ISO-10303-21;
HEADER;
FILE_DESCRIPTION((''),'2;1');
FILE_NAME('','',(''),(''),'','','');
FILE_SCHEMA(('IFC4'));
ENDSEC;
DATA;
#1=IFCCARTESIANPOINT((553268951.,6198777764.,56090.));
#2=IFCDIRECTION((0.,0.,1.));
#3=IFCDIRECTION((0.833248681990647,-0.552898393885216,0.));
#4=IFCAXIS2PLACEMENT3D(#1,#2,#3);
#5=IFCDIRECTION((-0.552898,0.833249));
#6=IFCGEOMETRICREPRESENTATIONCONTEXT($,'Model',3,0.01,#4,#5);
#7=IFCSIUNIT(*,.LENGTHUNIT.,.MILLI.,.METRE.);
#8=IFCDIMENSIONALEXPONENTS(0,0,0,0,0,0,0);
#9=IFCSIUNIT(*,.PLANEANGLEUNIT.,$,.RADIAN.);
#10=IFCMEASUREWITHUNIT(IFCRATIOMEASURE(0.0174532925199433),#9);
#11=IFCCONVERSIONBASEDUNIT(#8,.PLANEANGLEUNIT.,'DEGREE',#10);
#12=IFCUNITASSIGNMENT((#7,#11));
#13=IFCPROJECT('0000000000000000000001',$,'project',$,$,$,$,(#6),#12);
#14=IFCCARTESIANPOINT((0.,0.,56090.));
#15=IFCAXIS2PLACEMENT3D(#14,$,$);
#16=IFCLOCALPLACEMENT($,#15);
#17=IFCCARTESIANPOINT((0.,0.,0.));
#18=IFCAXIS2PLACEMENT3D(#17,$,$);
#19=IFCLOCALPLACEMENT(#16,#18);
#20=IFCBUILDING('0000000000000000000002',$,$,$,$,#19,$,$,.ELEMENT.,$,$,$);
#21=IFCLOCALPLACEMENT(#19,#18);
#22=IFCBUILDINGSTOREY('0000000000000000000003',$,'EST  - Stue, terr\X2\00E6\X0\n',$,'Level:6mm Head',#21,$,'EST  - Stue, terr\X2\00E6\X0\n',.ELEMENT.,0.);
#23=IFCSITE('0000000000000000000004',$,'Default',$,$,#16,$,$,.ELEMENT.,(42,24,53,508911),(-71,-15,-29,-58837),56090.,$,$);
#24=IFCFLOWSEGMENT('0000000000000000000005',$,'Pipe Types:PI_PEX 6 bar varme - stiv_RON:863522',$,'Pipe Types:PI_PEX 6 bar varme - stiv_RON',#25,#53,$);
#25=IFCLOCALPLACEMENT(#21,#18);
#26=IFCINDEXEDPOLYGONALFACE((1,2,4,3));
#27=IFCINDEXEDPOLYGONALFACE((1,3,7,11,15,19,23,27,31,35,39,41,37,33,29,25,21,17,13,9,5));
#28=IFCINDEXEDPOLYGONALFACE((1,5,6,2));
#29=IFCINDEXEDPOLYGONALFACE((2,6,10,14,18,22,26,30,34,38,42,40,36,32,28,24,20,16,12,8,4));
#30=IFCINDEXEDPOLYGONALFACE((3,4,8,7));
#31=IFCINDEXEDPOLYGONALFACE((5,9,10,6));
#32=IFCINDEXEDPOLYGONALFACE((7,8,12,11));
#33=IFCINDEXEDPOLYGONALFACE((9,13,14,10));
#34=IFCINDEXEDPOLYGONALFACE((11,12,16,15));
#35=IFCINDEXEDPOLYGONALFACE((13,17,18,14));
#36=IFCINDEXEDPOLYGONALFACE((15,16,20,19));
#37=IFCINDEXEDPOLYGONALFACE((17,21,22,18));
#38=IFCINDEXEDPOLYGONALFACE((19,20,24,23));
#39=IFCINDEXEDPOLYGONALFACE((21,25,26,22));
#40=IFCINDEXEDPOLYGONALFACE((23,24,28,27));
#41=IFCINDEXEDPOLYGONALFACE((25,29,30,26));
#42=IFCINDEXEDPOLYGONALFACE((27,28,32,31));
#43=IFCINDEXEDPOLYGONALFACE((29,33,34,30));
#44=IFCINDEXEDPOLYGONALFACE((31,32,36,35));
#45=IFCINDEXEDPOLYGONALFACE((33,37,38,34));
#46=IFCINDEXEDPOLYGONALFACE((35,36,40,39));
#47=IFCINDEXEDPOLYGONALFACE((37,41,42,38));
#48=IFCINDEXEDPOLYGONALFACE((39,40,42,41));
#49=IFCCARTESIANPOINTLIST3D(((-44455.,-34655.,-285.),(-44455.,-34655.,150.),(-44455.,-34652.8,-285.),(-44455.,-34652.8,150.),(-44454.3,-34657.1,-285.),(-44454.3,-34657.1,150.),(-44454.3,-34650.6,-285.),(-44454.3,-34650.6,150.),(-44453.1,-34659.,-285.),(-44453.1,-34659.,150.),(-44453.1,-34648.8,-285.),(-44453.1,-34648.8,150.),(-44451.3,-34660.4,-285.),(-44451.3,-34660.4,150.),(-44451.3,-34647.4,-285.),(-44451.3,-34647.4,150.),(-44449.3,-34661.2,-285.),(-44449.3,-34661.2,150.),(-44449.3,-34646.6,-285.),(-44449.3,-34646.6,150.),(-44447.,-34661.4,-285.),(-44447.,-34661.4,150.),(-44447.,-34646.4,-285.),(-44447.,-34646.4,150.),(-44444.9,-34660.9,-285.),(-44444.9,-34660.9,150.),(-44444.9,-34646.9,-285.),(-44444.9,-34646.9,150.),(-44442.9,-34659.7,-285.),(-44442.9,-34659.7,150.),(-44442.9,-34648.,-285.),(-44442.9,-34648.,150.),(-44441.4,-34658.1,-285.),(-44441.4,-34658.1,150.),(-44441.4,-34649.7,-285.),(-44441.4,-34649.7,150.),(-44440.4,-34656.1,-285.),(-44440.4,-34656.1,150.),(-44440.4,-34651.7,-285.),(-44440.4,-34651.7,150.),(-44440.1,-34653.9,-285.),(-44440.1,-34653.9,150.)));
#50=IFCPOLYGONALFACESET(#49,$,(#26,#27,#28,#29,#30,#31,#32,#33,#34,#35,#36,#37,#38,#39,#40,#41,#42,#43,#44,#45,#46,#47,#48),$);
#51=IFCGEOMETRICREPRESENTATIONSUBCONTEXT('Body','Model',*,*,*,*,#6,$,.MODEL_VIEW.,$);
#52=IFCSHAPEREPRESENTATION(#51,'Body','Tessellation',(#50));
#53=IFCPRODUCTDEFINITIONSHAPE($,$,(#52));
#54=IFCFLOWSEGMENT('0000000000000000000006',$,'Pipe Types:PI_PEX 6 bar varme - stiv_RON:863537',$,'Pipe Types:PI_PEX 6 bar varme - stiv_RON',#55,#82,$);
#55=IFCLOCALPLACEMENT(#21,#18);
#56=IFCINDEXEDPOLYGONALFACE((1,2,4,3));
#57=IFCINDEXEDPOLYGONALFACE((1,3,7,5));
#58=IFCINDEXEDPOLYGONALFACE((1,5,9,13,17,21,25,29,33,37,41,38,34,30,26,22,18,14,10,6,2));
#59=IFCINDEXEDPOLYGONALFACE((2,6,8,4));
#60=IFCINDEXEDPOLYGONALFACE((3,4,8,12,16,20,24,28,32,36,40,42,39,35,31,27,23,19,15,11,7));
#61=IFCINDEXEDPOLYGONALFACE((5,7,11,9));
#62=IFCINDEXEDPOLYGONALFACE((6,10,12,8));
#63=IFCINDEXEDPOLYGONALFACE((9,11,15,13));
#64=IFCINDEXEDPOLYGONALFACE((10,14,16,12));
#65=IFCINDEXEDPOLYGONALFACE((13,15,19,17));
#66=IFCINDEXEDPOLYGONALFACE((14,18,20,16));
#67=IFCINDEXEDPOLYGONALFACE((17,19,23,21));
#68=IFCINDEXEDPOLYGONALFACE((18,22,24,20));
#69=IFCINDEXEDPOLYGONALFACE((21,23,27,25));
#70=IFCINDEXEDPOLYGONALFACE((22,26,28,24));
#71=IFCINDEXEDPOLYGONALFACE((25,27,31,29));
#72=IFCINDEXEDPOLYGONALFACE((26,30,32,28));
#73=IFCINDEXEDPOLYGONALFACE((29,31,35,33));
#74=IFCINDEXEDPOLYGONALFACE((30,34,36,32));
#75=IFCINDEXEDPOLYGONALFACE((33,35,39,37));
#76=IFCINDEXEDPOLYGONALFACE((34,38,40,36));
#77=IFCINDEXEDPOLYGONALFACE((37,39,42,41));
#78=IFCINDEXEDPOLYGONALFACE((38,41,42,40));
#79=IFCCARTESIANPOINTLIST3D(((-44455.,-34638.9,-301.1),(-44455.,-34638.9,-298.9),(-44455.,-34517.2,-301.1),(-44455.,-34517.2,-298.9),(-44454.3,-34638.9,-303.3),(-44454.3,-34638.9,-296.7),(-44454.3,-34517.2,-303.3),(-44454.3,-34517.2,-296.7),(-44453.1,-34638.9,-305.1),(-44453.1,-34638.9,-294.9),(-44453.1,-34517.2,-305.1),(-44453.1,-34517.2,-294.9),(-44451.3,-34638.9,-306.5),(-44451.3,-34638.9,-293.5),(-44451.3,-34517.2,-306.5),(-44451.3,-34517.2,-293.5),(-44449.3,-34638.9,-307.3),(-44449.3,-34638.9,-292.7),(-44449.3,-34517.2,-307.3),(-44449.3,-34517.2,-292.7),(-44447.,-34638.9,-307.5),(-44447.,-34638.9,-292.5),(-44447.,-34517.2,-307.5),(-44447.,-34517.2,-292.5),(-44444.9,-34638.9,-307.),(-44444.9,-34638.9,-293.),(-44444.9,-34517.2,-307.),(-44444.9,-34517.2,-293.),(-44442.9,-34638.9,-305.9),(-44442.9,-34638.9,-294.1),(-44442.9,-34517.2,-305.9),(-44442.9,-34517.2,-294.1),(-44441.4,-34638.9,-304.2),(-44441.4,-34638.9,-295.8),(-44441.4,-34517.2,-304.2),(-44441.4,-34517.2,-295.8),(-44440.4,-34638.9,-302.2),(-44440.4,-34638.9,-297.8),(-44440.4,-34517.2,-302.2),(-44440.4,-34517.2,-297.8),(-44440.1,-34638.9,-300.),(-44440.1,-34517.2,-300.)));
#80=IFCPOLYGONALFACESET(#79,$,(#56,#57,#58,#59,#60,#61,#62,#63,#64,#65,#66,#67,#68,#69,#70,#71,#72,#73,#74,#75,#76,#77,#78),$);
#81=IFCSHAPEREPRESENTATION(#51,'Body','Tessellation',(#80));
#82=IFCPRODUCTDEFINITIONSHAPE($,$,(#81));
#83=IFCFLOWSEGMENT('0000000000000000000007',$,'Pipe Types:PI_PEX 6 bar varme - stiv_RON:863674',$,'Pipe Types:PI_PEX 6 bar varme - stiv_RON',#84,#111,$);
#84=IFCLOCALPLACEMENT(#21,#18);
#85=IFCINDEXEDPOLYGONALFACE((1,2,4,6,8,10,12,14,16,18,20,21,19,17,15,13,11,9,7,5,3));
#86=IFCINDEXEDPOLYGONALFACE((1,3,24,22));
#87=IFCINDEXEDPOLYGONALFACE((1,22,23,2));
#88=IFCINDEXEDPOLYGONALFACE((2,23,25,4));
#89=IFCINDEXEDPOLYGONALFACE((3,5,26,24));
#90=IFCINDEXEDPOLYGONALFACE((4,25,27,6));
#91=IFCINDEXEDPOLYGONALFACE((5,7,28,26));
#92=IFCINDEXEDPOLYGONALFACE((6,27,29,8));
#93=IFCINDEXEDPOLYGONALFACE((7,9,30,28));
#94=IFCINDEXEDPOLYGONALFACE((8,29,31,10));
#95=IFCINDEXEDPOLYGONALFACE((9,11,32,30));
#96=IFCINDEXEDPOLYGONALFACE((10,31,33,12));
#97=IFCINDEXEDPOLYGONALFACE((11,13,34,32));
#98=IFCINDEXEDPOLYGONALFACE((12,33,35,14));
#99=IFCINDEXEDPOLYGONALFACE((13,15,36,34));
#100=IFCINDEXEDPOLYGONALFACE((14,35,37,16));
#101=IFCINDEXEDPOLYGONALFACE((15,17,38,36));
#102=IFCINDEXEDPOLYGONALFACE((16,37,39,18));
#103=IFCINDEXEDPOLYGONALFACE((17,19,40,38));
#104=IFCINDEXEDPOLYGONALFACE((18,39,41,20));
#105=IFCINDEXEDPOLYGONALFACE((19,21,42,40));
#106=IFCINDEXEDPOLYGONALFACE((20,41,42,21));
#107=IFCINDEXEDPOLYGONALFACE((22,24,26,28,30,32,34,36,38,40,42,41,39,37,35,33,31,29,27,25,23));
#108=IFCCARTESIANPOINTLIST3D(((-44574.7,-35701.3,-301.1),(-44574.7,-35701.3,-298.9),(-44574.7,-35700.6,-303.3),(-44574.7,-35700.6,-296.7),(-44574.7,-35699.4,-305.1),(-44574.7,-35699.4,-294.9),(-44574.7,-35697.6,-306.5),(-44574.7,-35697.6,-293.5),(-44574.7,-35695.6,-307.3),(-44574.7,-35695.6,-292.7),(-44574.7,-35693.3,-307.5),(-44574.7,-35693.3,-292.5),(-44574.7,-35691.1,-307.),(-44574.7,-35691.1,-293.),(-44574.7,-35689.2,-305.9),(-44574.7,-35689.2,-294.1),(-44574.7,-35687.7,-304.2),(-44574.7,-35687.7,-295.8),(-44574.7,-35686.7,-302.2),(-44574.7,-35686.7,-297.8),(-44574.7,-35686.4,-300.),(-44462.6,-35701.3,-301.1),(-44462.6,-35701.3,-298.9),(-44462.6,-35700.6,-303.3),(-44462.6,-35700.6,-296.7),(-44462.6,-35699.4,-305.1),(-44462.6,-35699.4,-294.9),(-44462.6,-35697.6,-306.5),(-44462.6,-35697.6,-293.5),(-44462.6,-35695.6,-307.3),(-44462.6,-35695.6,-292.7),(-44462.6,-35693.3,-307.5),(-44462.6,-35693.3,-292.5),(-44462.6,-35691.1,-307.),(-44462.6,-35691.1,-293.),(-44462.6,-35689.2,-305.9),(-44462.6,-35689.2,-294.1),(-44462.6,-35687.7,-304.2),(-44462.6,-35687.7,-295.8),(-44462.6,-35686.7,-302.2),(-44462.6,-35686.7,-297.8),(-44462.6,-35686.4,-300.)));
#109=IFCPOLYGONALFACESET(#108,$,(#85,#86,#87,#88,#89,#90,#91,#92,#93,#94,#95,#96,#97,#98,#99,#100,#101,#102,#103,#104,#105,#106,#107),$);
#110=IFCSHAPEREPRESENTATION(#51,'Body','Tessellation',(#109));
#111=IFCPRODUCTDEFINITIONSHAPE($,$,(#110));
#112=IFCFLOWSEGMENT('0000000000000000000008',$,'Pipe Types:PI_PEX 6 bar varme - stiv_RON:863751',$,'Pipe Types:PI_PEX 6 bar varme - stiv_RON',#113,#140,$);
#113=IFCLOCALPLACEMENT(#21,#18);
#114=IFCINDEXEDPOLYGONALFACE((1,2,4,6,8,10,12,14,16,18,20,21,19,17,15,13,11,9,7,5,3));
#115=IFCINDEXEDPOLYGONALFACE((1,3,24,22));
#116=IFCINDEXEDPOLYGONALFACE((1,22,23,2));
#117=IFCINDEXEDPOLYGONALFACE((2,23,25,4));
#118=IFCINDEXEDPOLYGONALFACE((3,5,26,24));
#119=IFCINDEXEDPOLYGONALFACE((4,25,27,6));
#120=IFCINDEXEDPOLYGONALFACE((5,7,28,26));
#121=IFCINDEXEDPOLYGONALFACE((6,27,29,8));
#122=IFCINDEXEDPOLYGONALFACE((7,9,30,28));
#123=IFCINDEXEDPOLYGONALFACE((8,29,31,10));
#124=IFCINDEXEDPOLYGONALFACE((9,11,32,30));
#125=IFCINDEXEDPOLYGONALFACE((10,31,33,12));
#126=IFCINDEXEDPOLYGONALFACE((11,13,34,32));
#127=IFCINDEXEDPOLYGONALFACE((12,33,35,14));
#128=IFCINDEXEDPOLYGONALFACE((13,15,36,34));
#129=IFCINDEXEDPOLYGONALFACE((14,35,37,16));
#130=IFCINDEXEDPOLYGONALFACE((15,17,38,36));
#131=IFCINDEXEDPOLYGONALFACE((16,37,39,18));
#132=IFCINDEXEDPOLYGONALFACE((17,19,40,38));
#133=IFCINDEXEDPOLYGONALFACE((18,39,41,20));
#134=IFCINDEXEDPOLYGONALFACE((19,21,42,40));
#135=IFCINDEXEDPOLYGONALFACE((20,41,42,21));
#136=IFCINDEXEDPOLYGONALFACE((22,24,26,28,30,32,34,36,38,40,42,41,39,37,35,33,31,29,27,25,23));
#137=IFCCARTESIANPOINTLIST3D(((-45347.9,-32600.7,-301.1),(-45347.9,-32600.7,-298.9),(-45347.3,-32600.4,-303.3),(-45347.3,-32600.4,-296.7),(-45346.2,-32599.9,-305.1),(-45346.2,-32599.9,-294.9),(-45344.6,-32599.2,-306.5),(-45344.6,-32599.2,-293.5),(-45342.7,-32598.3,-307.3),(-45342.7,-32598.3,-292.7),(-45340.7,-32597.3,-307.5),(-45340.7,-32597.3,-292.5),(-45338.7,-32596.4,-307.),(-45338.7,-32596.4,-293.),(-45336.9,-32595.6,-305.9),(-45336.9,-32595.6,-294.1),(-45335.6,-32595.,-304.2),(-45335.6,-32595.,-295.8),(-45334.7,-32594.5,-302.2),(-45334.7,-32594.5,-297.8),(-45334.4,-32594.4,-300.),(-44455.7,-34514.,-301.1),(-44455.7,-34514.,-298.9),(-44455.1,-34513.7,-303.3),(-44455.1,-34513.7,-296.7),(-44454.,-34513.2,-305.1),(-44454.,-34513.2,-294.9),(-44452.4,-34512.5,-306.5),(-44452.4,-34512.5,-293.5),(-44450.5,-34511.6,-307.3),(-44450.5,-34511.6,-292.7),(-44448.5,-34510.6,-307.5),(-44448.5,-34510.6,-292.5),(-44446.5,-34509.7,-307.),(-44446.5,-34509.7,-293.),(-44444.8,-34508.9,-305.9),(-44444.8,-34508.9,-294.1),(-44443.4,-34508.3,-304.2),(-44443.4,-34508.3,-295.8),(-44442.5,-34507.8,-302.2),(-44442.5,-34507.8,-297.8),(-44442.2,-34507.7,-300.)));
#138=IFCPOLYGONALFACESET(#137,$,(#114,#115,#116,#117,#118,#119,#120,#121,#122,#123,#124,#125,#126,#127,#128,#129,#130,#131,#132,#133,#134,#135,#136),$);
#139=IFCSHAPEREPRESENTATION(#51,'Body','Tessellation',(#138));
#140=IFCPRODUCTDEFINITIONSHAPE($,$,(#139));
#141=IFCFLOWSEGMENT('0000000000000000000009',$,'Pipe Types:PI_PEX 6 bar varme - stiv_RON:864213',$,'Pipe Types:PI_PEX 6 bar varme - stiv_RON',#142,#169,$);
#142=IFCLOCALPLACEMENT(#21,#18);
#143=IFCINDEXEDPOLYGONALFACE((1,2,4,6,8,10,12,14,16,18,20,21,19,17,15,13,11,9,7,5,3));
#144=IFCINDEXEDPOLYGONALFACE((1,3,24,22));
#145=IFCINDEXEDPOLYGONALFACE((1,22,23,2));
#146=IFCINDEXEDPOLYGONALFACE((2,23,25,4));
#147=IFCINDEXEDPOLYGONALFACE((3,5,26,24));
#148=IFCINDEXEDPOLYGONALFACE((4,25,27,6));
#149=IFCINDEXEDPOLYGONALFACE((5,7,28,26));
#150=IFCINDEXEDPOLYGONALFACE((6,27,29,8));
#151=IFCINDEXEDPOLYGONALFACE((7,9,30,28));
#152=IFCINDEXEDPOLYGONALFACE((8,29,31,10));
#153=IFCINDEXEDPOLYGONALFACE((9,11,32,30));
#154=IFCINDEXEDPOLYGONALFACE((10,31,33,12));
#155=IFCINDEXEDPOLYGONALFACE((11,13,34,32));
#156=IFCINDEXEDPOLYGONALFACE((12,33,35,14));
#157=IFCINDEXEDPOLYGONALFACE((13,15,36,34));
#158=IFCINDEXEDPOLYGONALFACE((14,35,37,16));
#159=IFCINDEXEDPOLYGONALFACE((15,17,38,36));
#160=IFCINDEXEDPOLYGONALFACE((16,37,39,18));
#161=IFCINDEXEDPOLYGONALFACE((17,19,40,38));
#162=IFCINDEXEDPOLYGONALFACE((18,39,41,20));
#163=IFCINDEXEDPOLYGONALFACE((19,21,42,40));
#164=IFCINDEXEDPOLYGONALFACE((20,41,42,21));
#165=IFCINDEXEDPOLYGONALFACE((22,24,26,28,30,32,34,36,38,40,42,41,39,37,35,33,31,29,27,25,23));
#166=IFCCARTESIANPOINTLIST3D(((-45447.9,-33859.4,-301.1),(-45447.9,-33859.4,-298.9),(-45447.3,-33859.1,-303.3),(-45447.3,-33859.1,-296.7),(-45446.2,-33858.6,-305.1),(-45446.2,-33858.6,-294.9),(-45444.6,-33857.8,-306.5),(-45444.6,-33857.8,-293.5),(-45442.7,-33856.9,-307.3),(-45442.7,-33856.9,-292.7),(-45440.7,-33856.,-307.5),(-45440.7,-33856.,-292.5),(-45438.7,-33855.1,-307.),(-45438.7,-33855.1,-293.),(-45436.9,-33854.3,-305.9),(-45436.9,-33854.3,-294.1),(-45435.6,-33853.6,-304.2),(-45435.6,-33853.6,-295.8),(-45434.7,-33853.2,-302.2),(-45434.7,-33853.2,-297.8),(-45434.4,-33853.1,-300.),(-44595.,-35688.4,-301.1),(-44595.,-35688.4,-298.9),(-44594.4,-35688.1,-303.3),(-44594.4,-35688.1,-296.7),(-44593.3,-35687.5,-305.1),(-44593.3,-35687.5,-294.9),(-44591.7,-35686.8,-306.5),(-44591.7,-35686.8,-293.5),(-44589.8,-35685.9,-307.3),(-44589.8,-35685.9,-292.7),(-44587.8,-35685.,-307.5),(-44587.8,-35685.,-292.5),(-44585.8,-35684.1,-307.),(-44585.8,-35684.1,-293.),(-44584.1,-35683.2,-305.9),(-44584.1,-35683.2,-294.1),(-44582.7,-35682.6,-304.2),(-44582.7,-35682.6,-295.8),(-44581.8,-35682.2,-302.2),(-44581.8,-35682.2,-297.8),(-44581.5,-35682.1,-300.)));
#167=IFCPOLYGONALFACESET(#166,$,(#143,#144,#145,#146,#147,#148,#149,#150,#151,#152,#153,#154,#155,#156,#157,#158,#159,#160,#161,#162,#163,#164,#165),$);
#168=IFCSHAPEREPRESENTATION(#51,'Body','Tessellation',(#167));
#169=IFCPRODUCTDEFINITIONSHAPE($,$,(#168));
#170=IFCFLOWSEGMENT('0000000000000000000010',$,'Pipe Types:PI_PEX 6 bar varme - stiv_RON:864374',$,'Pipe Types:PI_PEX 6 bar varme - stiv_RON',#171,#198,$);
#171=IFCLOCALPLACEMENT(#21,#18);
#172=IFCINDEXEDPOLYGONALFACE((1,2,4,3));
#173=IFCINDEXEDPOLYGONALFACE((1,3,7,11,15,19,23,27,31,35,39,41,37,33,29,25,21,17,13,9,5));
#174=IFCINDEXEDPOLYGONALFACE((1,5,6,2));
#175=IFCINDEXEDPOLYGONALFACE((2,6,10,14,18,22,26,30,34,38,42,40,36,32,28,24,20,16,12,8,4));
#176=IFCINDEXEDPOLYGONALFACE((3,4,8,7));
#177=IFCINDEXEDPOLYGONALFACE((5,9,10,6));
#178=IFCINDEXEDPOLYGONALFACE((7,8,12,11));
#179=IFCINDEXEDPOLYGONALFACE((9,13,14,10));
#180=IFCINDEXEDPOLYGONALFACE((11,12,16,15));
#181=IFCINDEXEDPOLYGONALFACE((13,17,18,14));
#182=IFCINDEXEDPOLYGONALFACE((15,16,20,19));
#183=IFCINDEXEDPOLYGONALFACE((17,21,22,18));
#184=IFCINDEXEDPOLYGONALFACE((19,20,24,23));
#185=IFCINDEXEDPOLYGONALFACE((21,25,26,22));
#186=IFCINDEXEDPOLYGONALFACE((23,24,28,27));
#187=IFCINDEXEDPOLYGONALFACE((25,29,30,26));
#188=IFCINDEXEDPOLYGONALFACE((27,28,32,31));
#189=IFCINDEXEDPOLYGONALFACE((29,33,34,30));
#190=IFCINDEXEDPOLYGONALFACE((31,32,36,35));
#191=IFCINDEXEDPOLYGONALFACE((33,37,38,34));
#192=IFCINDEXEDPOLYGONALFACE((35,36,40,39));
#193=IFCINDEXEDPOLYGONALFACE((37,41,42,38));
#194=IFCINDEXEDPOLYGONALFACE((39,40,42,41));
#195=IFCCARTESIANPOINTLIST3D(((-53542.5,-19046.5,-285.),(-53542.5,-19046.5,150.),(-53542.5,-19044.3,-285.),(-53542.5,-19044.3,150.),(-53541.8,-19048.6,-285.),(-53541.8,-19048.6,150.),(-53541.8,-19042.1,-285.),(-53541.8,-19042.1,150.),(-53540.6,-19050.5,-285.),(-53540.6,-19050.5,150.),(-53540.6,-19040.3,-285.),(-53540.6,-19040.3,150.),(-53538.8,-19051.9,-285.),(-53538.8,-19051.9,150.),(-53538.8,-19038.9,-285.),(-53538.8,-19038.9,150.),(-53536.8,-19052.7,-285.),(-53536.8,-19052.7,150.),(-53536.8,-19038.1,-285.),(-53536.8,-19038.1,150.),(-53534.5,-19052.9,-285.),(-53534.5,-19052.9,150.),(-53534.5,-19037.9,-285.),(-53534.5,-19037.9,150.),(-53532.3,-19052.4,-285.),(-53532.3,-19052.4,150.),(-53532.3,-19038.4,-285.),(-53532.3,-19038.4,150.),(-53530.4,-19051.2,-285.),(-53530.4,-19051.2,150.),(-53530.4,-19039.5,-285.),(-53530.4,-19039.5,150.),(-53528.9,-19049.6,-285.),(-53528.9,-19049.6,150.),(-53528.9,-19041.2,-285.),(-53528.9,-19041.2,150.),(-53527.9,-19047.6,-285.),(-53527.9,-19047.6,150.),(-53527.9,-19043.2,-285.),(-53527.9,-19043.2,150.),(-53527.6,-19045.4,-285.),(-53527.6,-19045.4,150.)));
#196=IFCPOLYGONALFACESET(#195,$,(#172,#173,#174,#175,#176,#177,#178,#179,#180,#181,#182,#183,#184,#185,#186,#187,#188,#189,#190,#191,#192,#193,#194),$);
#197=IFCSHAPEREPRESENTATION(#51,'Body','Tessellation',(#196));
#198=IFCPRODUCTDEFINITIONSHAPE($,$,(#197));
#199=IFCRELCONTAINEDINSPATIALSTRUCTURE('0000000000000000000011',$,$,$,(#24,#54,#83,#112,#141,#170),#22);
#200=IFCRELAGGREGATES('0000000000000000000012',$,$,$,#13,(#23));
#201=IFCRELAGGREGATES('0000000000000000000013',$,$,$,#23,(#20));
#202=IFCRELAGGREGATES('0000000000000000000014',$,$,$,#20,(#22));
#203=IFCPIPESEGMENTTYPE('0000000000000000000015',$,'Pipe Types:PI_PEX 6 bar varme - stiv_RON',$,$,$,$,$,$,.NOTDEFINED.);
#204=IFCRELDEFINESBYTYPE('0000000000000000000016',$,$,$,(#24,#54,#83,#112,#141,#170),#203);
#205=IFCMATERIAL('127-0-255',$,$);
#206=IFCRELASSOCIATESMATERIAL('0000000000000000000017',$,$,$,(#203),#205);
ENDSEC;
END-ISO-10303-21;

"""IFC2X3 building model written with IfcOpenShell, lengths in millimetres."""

from ifc_helpers import new_model, entity, si_unit, converted_unit, direction, frame, frame_2d, origin, origin_2d_with_axis, place, context, subcontext, project, spatial, circle, extrude, material, type_object, element, save


model = new_model("IFC2X3")

# Units and contexts
model_context = context("Model", 3, precision=0.01, world=frame((553268951.0, 6198777764.0, 56090.0), z_axis=(0.0, 0.0, 1.0), x_axis=(0.833248681990647, -0.552898393885216, 0.0)), true_north=direction((-0.552898, 0.833249)))
body_context = subcontext(model_context, "Body", "Model", "MODEL_VIEW")
ifc_project = project(units=[si_unit("LENGTHUNIT", "METRE", prefix="MILLI"), converted_unit("PLANEANGLEUNIT", "DEGREE", entity("IfcRatioMeasure", 0.0174532925199433), si_unit("PLANEANGLEUNIT", "RADIAN"), dimensions=[0, 0, 0, 0, 0, 0, 0])], contexts=[model_context])

# Site, building, storey
site_placement = place(None, frame((0.0, 0.0, 56090.0)))
site = spatial("IfcSite", under=ifc_project, at=site_placement, Name="Default", CompositionType="ELEMENT", RefLatitude=(42, 24, 53, 508911), RefLongitude=(-71, -15, -29, -58837), RefElevation=56090.0)
building_placement = place(site_placement, origin())
building = spatial("IfcBuilding", under=site, at=building_placement, CompositionType="ELEMENT")
storey_placement = place(building_placement, frame((0.0, 0.0, 0.0)))
storey = spatial("IfcBuildingStorey", under=building, at=storey_placement, Name="EST  - Stue, terræn", ObjectType="Level:6mm Head", LongName="EST  - Stue, terræn", CompositionType="ELEMENT", Elevation=0.0)

# Flow segments
ifc_material = material(Name="127-0-255")
pipe_segment_type = type_object("IfcPipeSegmentType", Name="Pipe Types:PI_PEX 6 bar varme - stiv_RON", PredefinedType="NOTDEFINED", material=ifc_material)
flow_segment_1_placement = place(storey_placement, origin())
element("IfcFlowSegment", 1, at=flow_segment_1_placement, inside=storey, type_object=pipe_segment_type, Name="Pipe Types:PI_PEX 6 bar varme - stiv_RON:863522", ObjectType="Pipe Types:PI_PEX 6 bar varme - stiv_RON", context=body_context, shape_type="SweptSolid", body=[
    extrude(circle(Radius=7.5, at=origin_2d_with_axis()), frame((-44447.6, -34653.9, -285.0)), (0.0, 0.0, 1.0), 435.0),
])
flow_segment_2_placement = place(storey_placement, origin())
element("IfcFlowSegment", 2, at=flow_segment_2_placement, inside=storey, type_object=pipe_segment_type, Name="Pipe Types:PI_PEX 6 bar varme - stiv_RON:863537", ObjectType="Pipe Types:PI_PEX 6 bar varme - stiv_RON", context=body_context, shape_type="SweptSolid", body=[
    extrude(circle(Radius=7.5, at=origin_2d_with_axis()), frame((-44447.6, -34638.9, -300.0), z_axis=(0.0, 1.0, 0.0), x_axis=(1.0, 0.0, 0.0)), (0.0, 0.0, 1.0), 121.7),
])
flow_segment_3_placement = place(storey_placement, origin())
element("IfcFlowSegment", 3, at=flow_segment_3_placement, inside=storey, type_object=pipe_segment_type, Name="Pipe Types:PI_PEX 6 bar varme - stiv_RON:863674", ObjectType="Pipe Types:PI_PEX 6 bar varme - stiv_RON", context=body_context, shape_type="SweptSolid", body=[
    extrude(circle(Radius=7.5, at=origin_2d_with_axis()), frame((-44574.7, -35693.9, -300.0), z_axis=(1.0, 0.0, 0.0), x_axis=(0.0, 1.0, 0.0)), (0.0, 0.0, 1.0), 112.1),
])
flow_segment_4_placement = place(storey_placement, origin())
element("IfcFlowSegment", 4, at=flow_segment_4_placement, inside=storey, type_object=pipe_segment_type, Name="Pipe Types:PI_PEX 6 bar varme - stiv_RON:863751", ObjectType="Pipe Types:PI_PEX 6 bar varme - stiv_RON", context=body_context, shape_type="SweptSolid", body=[
    extrude(circle(Radius=7.5, at=frame_2d((0.0, 0.0), x_axis=(1.0, 0.0))), frame((-45341.2, -32597.6, -300.0), z_axis=(0.422618, -0.906308, 0.0), x_axis=(0.906308, 0.422618, 0.0)), (0.0, 0.0, 1.0), 2111.1),
])
flow_segment_5_placement = place(storey_placement, origin())
element("IfcFlowSegment", 5, at=flow_segment_5_placement, inside=storey, type_object=pipe_segment_type, Name="Pipe Types:PI_PEX 6 bar varme - stiv_RON:864213", ObjectType="Pipe Types:PI_PEX 6 bar varme - stiv_RON", context=body_context, shape_type="SweptSolid", body=[
    extrude(circle(Radius=7.5, at=origin_2d_with_axis()), frame((-45441.2, -33856.2, -300.0), z_axis=(0.422618, -0.906308, 0.0), x_axis=(0.906308, 0.422618, 0.0)), (0.0, 0.0, 1.0), 2018.1),
])
flow_segment_6_placement = place(storey_placement, origin())
element("IfcFlowSegment", 6, at=flow_segment_6_placement, inside=storey, type_object=pipe_segment_type, Name="Pipe Types:PI_PEX 6 bar varme - stiv_RON:864374", ObjectType="Pipe Types:PI_PEX 6 bar varme - stiv_RON", context=body_context, shape_type="SweptSolid", body=[
    extrude(circle(Radius=7.5, at=frame_2d((0.0, 0.0), x_axis=(1.0, 0.0))), frame((-53535.1, -19045.4, -285.0)), (0.0, 0.0, 1.0), 435.0),
])

save(model, "model.ifc")
